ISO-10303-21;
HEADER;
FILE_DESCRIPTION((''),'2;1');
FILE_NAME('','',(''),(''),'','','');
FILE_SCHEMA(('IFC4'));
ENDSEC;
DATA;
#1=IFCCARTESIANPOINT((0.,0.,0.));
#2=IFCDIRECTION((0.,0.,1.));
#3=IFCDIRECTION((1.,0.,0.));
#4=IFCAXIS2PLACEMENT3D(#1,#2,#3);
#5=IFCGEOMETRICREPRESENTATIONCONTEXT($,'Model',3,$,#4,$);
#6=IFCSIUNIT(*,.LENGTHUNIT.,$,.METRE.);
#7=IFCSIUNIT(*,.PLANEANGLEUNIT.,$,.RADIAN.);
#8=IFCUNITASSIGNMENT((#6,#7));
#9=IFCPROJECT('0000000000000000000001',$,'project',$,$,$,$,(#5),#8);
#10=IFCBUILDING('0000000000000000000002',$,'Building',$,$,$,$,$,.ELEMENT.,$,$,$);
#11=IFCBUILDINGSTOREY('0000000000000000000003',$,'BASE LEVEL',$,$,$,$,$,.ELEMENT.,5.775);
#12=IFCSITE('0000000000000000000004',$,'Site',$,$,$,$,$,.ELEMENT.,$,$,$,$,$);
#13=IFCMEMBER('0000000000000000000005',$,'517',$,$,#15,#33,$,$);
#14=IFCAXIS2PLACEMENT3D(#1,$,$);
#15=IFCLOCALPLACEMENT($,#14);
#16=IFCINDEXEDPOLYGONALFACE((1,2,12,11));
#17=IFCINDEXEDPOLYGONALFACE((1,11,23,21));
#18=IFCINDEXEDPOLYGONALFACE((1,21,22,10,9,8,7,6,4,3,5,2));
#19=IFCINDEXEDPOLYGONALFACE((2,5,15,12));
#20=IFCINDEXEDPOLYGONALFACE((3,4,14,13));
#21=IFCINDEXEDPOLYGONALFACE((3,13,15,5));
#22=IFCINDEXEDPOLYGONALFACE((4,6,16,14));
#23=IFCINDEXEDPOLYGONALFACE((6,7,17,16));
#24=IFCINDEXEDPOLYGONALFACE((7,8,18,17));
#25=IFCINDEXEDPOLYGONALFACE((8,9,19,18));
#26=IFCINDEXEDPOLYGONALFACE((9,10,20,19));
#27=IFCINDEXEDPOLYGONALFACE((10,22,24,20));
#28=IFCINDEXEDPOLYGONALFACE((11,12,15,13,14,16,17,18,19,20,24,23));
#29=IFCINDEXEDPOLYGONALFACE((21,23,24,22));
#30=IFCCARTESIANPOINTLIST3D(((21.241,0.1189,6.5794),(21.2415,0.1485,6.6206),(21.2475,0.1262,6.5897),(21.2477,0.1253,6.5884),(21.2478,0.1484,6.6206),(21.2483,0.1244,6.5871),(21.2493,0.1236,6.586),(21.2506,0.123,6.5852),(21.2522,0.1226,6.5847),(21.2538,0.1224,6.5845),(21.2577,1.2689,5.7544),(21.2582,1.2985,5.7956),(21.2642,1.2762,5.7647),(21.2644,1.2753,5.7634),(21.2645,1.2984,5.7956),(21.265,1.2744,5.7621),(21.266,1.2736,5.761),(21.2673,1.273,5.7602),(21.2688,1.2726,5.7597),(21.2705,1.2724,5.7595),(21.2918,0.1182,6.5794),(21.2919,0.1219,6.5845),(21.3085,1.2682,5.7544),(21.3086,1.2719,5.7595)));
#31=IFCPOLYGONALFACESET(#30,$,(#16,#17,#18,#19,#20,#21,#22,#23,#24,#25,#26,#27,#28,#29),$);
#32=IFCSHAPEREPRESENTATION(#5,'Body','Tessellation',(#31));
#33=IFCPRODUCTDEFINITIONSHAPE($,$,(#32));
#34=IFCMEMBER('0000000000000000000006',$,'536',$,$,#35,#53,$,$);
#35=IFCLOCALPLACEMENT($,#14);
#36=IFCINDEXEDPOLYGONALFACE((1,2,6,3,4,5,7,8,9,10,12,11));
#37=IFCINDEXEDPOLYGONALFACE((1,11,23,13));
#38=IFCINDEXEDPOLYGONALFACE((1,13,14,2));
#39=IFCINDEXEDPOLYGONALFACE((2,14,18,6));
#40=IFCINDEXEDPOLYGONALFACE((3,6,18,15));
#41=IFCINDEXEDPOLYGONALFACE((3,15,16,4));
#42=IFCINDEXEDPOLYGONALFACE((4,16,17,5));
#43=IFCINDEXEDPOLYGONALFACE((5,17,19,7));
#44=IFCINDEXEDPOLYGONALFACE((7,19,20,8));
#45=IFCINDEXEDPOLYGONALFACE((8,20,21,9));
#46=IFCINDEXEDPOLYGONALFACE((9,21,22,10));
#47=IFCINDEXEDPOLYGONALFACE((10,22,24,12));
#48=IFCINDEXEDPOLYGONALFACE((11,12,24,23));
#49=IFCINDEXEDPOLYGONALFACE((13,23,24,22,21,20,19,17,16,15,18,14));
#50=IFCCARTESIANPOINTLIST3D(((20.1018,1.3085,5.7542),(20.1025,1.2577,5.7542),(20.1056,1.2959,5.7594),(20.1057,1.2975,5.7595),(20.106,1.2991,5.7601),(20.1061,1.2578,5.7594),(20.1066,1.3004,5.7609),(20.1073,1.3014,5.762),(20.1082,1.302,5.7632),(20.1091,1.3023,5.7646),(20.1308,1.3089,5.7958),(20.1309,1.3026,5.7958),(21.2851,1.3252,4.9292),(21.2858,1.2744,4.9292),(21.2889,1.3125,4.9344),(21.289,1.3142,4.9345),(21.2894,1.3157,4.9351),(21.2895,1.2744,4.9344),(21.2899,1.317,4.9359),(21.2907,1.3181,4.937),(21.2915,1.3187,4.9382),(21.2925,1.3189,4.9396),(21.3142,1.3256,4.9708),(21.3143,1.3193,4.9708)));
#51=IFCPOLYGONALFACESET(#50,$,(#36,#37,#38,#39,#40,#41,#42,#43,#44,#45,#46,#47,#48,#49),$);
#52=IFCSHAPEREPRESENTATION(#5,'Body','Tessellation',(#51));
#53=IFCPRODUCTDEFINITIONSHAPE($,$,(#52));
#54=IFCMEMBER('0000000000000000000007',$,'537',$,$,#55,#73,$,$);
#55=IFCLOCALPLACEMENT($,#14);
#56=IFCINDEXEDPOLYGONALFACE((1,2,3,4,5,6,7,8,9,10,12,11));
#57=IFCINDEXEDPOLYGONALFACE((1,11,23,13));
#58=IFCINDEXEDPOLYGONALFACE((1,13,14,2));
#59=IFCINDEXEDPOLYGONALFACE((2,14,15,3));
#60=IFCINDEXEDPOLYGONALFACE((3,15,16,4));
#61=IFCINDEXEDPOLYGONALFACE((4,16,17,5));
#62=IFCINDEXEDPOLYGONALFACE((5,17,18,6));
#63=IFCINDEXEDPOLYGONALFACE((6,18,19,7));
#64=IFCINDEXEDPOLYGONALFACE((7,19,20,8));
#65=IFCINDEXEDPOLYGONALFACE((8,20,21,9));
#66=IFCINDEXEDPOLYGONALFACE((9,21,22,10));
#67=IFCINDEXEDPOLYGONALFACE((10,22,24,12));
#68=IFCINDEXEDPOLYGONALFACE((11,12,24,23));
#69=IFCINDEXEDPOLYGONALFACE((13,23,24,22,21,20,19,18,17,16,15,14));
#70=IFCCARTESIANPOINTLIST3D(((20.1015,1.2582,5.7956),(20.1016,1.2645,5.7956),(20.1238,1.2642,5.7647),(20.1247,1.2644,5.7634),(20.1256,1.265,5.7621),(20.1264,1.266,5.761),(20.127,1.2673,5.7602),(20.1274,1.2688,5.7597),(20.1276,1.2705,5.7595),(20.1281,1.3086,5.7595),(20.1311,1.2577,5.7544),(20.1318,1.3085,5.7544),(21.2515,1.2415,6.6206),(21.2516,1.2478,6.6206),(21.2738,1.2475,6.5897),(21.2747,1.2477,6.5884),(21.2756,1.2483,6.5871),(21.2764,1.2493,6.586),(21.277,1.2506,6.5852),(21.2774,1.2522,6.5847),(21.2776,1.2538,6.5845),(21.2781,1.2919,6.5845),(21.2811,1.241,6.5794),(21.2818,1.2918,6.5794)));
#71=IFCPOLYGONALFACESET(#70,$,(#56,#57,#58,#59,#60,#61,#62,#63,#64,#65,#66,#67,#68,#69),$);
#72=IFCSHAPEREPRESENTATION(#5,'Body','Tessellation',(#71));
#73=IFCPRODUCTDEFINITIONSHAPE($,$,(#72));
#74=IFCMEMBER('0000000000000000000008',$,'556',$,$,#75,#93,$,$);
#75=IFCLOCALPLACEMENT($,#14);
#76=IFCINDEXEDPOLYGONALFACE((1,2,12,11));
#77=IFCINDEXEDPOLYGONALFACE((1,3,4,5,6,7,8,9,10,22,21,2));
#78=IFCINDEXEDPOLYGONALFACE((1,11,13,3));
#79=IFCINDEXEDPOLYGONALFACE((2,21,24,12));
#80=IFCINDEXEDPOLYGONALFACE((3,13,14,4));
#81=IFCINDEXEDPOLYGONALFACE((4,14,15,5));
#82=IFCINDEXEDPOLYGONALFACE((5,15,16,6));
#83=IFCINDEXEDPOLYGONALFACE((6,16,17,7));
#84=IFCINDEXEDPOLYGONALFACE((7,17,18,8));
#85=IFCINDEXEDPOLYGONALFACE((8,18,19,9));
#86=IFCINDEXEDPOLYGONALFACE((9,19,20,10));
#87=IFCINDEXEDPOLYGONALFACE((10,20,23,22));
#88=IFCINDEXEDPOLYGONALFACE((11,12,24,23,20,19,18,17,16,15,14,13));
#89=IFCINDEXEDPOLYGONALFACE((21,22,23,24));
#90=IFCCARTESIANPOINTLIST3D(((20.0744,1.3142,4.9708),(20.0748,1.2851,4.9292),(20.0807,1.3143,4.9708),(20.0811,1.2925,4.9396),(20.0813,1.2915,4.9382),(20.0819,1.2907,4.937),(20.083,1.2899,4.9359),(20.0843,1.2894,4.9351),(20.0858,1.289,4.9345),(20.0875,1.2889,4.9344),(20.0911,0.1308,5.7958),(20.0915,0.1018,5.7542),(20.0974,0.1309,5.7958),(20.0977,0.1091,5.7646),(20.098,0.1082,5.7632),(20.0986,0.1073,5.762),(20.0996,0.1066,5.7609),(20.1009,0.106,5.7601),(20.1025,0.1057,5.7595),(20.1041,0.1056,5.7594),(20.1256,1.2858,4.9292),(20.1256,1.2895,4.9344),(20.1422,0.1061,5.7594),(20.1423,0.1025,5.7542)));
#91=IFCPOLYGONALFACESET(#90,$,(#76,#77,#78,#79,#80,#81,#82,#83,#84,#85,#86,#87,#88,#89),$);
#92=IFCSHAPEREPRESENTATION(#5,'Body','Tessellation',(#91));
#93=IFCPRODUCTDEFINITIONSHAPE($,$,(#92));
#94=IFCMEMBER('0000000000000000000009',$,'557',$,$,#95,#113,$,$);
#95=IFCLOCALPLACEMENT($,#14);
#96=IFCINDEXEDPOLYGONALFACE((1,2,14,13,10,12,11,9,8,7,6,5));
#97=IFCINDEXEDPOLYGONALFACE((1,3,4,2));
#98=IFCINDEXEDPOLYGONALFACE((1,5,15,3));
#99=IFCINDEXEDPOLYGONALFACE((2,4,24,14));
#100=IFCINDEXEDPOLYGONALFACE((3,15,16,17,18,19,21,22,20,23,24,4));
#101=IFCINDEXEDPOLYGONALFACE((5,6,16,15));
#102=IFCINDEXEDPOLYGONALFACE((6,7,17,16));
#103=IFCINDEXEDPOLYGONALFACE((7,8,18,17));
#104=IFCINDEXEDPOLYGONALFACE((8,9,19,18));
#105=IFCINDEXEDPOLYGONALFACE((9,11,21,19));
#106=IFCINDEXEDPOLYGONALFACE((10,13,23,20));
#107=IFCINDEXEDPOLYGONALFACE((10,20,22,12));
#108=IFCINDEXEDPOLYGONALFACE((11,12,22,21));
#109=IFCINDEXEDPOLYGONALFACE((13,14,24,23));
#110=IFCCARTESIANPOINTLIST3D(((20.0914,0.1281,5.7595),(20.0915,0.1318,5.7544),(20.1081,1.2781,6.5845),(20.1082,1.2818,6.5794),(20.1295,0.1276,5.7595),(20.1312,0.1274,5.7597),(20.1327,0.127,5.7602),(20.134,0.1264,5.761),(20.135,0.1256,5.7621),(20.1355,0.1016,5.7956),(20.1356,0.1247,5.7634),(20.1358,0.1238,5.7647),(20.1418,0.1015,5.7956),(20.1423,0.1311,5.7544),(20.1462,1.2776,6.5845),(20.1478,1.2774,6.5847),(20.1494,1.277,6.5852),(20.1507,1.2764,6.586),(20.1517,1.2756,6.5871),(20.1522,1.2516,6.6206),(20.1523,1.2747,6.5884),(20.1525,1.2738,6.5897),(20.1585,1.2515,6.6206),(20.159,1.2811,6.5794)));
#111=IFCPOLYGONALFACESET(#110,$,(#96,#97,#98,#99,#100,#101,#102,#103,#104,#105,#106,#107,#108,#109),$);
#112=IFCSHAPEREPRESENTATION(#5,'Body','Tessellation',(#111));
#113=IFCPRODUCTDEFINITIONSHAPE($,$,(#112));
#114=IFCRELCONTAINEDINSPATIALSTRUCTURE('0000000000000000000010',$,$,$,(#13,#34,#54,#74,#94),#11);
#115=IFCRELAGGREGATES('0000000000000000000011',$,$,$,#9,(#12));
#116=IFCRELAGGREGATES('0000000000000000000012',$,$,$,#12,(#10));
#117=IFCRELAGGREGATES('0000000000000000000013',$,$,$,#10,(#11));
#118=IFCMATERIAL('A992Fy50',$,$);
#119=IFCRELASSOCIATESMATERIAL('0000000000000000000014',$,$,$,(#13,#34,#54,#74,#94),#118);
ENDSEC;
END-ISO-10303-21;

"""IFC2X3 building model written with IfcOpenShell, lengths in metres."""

from ifc_helpers import new_model, si_unit, frame, origin_with_axes, origin_2d_with_axis, place, context, project, spatial, l_section, extrude, material, element, save


model = new_model("IFC2X3")

# Units and contexts
model_context = context("Model", 3, world=origin_with_axes())
ifc_project = project(units=[si_unit("LENGTHUNIT", "METRE"), si_unit("PLANEANGLEUNIT", "RADIAN")], contexts=[model_context])

# Site, building, storey
site = spatial("IfcSite", under=ifc_project, Name="Site", CompositionType="ELEMENT")
building = spatial("IfcBuilding", under=site, Name="Building", CompositionType="ELEMENT")
storey = spatial("IfcBuildingStorey", under=building, Name="BASE LEVEL", CompositionType="ELEMENT", Elevation=5.775)

# Shared definitions
ifc_material = material(Name="A992Fy50")

# Members
member_1_placement = place(None, frame((21.2833, 1.2833, 5.775), z_axis=(-0.011775, -0.812482, 0.582867), x_axis=(0.999882, -0.015383, 0.0)))
element("IfcMember", 1, at=member_1_placement, inside=storey, material=ifc_material, Name="517", context=model_context, shape_type="SweptSolid", body=[
    extrude(l_section(Depth=0.0508, Width=0.0508, Thickness=0.0063, FilletRadius=0.0063, at=origin_2d_with_axis()), origin_with_axes(), (0.0, 0.0, 1.0), 1.4154),
])
member_2_placement = place(None, frame((21.3, 1.3, 4.95), z_axis=(-0.820261, -0.011553, 0.571872), x_axis=(0.014083, -0.999901, 0.0)))
element("IfcMember", 2, at=member_2_placement, inside=storey, material=ifc_material, Name="536", context=model_context, shape_type="SweptSolid", body=[
    extrude(l_section(Depth=0.0508, Width=0.0508, Thickness=0.0063, FilletRadius=0.0063, at=origin_2d_with_axis()), origin_with_axes(), (0.0, 0.0, 1.0), 1.4426),
])
member_3_placement = place(None, frame((20.1167, 1.2833, 5.775), z_axis=(0.812482, -0.011775, 0.582867), x_axis=(0.015383, 0.999882, 0.0)))
element("IfcMember", 3, at=member_3_placement, inside=storey, material=ifc_material, Name="537", context=model_context, shape_type="SweptSolid", body=[
    extrude(l_section(Depth=0.0508, Width=0.0508, Thickness=0.0063, FilletRadius=0.0063, at=origin_2d_with_axis()), origin_with_axes(), (0.0, 0.0, 1.0), 1.4154),
])
member_4_placement = place(None, frame((20.1, 1.3, 4.95), z_axis=(0.011553, -0.820261, 0.571872), x_axis=(0.999889, 0.014924, 0.0)))
element("IfcMember", 4, at=member_4_placement, inside=storey, material=ifc_material, Name="556", context=model_context, shape_type="SweptSolid", body=[
    extrude(l_section(Depth=0.0508, Width=0.0508, Thickness=0.0063, FilletRadius=0.0063, at=origin_2d_with_axis()), origin_with_axes(), (0.0, 0.0, 1.0), 1.4426),
])
member_5_placement = place(None, frame((20.1167, 0.1167, 5.775), z_axis=(0.011775, 0.812482, 0.582867), x_axis=(-0.999882, 0.015383, 0.0)))
element("IfcMember", 5, at=member_5_placement, inside=storey, material=ifc_material, Name="557", context=model_context, shape_type="SweptSolid", body=[
    extrude(l_section(Depth=0.0508, Width=0.0508, Thickness=0.0063, FilletRadius=0.0063, at=origin_2d_with_axis()), origin_with_axes(), (0.0, 0.0, 1.0), 1.4154),
])

save(model, "model.ifc")
